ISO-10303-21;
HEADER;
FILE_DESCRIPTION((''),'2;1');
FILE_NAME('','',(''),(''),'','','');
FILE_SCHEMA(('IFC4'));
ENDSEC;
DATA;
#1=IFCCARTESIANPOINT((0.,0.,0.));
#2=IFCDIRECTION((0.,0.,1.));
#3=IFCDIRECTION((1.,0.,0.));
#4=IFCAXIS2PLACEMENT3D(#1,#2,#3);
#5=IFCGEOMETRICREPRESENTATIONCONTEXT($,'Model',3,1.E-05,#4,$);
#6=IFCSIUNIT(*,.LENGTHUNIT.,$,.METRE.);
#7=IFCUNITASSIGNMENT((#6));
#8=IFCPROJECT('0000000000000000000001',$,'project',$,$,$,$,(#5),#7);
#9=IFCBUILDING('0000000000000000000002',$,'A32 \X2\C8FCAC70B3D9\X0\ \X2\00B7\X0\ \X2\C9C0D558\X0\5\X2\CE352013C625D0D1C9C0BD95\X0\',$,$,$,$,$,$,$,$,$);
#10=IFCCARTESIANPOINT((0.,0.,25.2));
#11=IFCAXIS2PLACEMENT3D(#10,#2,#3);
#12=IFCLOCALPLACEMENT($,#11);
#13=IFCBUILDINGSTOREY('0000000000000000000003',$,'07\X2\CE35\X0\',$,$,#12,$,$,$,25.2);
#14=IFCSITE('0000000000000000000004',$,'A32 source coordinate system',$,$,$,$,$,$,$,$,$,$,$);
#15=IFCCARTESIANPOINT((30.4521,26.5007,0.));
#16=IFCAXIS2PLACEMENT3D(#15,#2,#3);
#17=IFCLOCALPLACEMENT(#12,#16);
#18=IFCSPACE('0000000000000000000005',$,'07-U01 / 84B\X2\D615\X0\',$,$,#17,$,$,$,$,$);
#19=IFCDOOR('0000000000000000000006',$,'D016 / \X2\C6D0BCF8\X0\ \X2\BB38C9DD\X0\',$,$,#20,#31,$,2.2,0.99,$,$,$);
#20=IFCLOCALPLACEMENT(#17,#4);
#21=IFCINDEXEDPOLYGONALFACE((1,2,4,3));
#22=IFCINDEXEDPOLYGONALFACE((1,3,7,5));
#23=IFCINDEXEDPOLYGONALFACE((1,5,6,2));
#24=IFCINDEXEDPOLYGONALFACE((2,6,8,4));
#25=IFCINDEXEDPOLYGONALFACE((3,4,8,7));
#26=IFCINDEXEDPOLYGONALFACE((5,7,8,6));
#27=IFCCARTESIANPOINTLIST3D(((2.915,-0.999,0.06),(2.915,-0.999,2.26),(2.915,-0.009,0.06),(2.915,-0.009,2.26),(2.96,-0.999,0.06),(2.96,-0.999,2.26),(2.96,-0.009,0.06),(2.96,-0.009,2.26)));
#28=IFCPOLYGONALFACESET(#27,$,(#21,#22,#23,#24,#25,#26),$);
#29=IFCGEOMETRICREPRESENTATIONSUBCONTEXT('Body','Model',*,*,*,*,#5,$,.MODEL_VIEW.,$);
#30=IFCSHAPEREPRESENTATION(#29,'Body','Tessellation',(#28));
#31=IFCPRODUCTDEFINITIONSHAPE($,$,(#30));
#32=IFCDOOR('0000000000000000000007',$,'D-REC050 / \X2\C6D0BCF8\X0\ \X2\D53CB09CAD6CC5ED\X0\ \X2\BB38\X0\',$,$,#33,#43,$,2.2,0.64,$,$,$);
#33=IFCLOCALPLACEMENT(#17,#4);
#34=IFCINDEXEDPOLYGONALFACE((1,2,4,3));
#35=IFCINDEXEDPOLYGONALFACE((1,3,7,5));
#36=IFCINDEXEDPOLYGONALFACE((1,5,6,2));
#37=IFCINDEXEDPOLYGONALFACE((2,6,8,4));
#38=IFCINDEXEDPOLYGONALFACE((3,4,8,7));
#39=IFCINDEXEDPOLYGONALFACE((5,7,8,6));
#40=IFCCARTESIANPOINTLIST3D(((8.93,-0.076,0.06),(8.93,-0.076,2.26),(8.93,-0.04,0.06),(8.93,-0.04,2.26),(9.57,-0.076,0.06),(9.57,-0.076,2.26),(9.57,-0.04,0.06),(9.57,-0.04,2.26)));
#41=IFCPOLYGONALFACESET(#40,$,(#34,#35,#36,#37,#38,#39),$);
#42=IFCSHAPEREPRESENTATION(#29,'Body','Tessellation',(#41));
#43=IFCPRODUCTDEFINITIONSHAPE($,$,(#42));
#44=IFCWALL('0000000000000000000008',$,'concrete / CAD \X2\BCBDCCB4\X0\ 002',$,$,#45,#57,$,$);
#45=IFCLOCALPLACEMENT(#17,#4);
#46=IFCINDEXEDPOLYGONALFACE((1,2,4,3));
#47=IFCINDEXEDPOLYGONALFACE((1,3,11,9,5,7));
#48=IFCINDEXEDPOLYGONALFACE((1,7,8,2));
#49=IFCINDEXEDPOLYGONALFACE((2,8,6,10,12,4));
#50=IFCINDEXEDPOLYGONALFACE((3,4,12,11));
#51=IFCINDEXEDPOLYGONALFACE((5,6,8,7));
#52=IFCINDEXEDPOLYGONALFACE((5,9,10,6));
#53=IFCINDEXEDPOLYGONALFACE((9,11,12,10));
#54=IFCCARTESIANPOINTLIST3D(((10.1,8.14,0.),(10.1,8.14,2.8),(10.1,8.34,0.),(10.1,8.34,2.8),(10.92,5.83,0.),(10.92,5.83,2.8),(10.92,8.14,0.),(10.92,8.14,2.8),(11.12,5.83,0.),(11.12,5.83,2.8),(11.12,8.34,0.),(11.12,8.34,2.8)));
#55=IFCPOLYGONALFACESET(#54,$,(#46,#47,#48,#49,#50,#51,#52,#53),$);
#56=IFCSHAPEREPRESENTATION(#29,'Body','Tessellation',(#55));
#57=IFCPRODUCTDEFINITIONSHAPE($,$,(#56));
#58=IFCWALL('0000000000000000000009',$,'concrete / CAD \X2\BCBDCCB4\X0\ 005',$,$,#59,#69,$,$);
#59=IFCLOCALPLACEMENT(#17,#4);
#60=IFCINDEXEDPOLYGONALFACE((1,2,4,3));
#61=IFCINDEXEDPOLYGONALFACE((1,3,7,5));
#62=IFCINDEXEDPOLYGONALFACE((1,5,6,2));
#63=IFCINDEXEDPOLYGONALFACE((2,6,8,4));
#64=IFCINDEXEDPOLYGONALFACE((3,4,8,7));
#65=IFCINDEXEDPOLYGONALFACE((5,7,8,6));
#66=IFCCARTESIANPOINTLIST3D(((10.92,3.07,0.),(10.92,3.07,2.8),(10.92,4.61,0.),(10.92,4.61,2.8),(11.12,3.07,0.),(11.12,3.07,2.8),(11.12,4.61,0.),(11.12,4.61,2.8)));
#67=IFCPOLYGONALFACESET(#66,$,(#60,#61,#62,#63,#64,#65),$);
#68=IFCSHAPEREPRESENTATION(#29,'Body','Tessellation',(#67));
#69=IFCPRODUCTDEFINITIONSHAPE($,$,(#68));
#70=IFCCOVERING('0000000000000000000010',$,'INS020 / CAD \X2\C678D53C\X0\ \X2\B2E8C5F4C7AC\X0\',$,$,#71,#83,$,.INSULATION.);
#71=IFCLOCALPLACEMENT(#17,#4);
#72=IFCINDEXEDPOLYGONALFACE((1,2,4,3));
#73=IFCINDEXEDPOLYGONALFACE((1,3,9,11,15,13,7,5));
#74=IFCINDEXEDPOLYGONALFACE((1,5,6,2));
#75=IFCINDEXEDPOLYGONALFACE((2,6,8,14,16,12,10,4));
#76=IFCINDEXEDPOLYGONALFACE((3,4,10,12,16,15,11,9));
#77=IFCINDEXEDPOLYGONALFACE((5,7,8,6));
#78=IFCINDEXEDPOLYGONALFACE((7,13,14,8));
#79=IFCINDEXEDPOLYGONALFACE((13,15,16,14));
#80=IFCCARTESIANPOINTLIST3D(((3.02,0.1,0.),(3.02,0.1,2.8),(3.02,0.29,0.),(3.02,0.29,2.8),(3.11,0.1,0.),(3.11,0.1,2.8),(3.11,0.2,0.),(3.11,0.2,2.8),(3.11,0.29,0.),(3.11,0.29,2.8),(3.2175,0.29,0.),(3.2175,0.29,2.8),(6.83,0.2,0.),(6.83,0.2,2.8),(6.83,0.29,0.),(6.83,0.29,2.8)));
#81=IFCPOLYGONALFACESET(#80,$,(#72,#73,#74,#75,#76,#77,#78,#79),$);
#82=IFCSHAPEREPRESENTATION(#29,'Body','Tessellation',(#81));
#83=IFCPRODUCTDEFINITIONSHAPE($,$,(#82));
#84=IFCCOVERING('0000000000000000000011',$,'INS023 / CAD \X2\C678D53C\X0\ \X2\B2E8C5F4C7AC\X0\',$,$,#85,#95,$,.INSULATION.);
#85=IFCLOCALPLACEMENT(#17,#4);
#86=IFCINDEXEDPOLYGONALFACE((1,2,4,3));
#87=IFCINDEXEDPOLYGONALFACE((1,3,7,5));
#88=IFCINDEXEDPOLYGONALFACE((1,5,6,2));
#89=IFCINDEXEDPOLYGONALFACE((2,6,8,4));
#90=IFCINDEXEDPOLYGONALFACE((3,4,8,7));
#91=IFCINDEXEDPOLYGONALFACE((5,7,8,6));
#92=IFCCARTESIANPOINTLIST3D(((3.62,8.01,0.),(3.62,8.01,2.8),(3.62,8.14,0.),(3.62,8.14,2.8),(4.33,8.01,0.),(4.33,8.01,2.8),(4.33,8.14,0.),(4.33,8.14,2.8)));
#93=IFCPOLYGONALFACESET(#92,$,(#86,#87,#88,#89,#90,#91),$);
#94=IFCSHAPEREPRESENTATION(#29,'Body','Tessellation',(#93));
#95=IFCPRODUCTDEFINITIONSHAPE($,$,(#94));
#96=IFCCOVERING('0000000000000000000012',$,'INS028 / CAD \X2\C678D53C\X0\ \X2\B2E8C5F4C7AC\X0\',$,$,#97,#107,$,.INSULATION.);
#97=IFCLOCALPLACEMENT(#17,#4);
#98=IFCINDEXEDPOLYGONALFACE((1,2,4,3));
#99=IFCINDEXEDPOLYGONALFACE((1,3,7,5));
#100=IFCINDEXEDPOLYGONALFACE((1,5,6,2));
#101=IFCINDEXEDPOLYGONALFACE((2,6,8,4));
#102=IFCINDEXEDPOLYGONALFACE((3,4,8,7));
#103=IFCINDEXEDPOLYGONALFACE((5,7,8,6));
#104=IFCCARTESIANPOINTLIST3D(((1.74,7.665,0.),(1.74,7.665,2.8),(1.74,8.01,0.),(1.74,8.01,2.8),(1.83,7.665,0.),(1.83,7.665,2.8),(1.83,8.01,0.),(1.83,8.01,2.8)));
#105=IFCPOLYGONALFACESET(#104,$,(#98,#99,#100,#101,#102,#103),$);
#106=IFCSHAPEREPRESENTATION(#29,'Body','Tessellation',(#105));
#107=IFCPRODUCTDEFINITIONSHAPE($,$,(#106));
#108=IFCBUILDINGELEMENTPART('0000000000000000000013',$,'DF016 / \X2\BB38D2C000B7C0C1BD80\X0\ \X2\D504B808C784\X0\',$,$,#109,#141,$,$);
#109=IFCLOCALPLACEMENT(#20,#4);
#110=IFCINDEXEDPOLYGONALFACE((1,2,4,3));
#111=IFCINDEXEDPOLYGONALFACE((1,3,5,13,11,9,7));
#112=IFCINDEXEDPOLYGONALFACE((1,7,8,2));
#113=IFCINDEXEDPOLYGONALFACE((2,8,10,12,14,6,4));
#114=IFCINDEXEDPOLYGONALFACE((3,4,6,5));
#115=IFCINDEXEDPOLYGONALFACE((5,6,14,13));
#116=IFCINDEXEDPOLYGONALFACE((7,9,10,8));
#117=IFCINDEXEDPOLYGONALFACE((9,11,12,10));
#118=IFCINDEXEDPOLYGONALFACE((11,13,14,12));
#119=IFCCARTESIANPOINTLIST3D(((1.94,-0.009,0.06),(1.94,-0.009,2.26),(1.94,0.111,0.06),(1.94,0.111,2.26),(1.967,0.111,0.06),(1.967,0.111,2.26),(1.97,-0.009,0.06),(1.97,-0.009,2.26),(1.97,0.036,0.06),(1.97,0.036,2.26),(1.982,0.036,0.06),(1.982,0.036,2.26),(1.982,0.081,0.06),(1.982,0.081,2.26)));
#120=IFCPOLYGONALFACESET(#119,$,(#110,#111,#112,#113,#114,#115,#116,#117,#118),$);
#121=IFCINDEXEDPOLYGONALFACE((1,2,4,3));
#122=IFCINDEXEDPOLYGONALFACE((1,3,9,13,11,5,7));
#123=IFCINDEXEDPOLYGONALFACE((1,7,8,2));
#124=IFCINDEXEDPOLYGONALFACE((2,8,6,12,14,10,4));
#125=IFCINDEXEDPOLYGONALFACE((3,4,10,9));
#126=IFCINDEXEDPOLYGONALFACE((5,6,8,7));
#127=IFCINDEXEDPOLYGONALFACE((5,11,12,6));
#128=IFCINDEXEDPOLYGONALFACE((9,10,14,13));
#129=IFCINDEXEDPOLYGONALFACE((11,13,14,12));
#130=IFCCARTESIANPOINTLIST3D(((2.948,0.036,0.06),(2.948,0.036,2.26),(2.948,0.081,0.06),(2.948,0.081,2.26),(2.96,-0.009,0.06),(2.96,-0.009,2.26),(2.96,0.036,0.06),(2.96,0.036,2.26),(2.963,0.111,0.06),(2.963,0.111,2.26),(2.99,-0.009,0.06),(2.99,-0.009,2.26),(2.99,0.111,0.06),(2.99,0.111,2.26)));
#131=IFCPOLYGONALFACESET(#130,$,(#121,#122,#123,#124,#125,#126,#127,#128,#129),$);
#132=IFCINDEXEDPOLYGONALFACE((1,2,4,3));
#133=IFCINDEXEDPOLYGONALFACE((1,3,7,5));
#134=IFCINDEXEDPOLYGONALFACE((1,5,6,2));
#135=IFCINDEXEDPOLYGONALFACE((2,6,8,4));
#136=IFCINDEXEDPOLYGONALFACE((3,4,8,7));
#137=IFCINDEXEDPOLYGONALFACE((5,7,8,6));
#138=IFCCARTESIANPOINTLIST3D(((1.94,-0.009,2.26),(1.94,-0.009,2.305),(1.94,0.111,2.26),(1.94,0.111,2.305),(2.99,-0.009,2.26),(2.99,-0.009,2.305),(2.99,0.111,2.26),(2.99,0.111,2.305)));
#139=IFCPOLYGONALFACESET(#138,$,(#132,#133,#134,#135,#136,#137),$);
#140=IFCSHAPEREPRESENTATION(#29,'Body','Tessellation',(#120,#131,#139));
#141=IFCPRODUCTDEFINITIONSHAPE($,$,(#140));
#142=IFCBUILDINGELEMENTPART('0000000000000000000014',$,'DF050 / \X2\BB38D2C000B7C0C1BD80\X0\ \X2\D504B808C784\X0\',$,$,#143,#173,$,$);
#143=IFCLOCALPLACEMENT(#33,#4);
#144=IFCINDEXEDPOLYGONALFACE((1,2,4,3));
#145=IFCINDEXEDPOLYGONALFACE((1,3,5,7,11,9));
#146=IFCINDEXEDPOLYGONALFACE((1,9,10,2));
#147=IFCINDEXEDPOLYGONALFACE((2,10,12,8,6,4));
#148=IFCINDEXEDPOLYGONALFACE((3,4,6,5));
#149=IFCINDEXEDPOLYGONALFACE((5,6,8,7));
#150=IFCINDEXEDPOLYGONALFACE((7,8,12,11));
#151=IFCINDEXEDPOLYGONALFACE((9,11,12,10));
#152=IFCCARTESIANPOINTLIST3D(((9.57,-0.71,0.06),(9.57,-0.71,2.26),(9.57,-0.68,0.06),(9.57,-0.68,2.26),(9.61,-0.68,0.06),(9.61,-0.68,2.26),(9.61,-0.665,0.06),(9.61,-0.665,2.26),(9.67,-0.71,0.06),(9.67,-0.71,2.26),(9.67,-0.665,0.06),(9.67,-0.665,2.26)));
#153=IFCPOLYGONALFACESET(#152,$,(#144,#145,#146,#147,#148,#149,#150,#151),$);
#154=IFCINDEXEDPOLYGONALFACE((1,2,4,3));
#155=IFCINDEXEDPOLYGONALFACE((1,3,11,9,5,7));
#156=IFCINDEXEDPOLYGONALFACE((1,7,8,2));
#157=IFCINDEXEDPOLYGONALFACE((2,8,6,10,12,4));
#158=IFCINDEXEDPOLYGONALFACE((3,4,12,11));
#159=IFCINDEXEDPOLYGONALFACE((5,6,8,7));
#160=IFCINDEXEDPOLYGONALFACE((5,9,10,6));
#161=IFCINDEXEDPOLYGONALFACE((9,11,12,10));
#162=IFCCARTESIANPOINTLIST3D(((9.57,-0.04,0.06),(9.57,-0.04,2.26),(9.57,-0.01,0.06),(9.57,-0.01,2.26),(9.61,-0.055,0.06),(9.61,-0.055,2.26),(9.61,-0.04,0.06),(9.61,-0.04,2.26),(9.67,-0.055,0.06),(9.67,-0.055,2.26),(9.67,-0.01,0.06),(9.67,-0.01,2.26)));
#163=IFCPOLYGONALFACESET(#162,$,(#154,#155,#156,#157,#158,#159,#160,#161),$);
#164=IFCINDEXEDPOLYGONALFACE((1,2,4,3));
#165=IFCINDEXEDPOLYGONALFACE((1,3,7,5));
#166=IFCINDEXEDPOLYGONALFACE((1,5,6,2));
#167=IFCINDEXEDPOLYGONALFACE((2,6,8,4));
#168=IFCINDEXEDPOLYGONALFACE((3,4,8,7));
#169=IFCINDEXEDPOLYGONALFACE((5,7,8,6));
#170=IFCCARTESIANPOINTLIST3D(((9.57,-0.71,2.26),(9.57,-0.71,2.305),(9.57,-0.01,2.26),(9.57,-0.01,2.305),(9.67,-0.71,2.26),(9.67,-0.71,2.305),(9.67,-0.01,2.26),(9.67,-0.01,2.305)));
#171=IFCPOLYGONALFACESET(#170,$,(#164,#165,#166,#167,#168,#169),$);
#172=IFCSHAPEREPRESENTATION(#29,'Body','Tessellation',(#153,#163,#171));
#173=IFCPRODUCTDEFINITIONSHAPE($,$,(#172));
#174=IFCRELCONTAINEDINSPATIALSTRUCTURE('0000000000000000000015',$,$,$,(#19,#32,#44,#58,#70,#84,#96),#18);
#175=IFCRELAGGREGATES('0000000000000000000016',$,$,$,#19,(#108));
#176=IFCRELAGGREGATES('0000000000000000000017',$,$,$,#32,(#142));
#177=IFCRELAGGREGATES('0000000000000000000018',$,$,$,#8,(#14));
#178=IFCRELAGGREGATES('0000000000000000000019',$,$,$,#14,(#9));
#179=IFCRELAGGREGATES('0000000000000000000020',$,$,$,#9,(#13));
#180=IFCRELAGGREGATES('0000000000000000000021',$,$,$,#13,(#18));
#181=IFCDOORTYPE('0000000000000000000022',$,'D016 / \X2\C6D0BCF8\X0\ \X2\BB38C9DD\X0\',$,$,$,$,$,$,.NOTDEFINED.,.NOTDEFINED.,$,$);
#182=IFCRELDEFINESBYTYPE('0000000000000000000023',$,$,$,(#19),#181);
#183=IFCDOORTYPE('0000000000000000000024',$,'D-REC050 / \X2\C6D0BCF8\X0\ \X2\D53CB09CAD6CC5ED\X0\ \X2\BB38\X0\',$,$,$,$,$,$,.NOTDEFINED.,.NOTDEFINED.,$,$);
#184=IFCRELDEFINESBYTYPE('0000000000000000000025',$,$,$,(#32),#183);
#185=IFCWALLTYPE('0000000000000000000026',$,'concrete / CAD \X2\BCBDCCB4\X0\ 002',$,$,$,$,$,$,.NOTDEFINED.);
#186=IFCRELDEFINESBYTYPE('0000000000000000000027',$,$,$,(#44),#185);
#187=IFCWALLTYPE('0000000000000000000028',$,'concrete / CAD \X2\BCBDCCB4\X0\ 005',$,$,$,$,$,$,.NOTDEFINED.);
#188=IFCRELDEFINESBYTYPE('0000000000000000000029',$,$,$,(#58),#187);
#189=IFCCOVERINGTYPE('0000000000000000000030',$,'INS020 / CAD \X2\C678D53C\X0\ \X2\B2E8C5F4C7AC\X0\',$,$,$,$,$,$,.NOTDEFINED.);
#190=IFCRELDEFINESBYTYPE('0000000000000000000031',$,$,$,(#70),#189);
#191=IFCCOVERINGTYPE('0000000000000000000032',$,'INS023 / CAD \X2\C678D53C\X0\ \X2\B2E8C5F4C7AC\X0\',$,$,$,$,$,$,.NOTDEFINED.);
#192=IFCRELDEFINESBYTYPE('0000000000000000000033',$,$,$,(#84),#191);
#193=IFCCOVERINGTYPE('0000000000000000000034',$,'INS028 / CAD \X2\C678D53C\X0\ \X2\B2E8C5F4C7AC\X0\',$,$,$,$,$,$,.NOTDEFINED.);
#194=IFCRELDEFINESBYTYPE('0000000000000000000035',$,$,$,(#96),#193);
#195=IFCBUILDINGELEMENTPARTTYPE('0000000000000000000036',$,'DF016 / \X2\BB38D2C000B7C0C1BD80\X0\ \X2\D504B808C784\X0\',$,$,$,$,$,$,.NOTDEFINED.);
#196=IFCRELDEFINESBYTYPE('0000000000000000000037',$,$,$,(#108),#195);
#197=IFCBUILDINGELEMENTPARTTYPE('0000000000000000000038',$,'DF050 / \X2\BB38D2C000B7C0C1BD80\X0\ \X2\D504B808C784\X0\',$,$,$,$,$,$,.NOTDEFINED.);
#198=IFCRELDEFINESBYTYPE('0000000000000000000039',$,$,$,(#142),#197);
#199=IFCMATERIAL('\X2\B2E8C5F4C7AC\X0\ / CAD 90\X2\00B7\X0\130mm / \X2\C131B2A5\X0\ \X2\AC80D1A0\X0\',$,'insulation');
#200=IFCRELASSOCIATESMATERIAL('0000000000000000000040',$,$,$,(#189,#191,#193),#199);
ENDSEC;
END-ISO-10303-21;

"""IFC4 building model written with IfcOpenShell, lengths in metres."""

from ifc_helpers import new_model, si_unit, frame, origin, origin_with_axes, place, context, subcontext, project, spatial, polyline, outline, extrude, source, transform, mapped, material, type_object, type_shapes, element, aggregate, save


model = new_model("IFC4")

# Units and contexts
model_context = context("Model", 3, precision=1e-05, world=origin_with_axes())
body_context = subcontext(model_context, "Body", "Model", "MODEL_VIEW")
ifc_project = project(units=[si_unit("LENGTHUNIT", "METRE")], contexts=[model_context])

# Site, building, storey, space
storey_placement = place(None, frame((0.0, 0.0, 25.2), z_axis=(0.0, 0.0, 1.0), x_axis=(1.0, 0.0, 0.0)))
space_placement = place(storey_placement, frame((30.4521, 26.5007, 0.0), z_axis=(0.0, 0.0, 1.0), x_axis=(1.0, 0.0, 0.0)))
site = spatial("IfcSite", under=ifc_project, Name="A32 source coordinate system")
building = spatial("IfcBuilding", under=site, Name="A32 주거동 · 지하5층–옥탑지붕")
storey = spatial("IfcBuildingStorey", under=building, at=storey_placement, Name="07층", Elevation=25.2)
space = spatial("IfcSpace", under=storey, at=space_placement, Name="07-U01 / 84B형")

# Doors
door_type_1 = type_object("IfcDoorType", Name="D016 / 원본 문짝", OperationType="NOTDEFINED", PredefinedType="NOTDEFINED")
shared_shape_1 = source(origin(), body_context, "Body", "SweptSolid", [
    extrude(outline(polyline([(2.96, -0.009), (2.96, -0.999), (2.915, -0.999), (2.915, -0.009), (2.96, -0.009)])), frame((0.0, 0.0, 0.06)), (0.0, 0.0, 1.0), 2.2),
])
type_shapes(door_type_1, [shared_shape_1])
door_1_placement = place(space_placement, origin_with_axes())
door_1 = element("IfcDoor", 1, at=door_1_placement, inside=space, type_object=door_type_1, Name="D016 / 원본 문짝", OverallHeight=2.2, OverallWidth=0.99, context=body_context, shape_type="MappedRepresentation", body=[
    mapped(shared_shape_1, transform((0.0, 0.0, 0.0), scale=1.0)),
])
door_type_2 = type_object("IfcDoorType", Name="D-REC050 / 원본 피난구역 문", OperationType="NOTDEFINED", PredefinedType="NOTDEFINED")
shared_shape_2 = source(origin(), body_context, "Body", "SweptSolid", [
    extrude(outline(polyline([(9.57, -0.04), (9.57, -0.076), (8.93, -0.076), (8.93, -0.04), (9.57, -0.04)])), frame((0.0, 0.0, 0.06)), (0.0, 0.0, 1.0), 2.2),
])
type_shapes(door_type_2, [shared_shape_2])
door_2_placement = place(space_placement, origin_with_axes())
door_2 = element("IfcDoor", 2, at=door_2_placement, inside=space, type_object=door_type_2, Name="D-REC050 / 원본 피난구역 문", OverallHeight=2.2, OverallWidth=0.64, context=body_context, shape_type="MappedRepresentation", body=[
    mapped(shared_shape_2, transform((0.0, 0.0, 0.0), scale=1.0)),
])

# Walls
wall_type_1 = type_object("IfcWallType", Name="concrete / CAD 벽체 002", PredefinedType="NOTDEFINED")
shared_shape_3 = source(origin(), body_context, "Body", "SweptSolid", [
    extrude(outline(polyline([(11.12, 5.83), (10.92, 5.83), (10.92, 8.14), (10.1, 8.14), (10.1, 8.34), (11.12, 8.34), (11.12, 5.83)])), origin(), (0.0, 0.0, 1.0), 2.8),
])
type_shapes(wall_type_1, [shared_shape_3])
wall_1_placement = place(space_placement, origin_with_axes())
element("IfcWall", 3, at=wall_1_placement, inside=space, type_object=wall_type_1, Name="concrete / CAD 벽체 002", context=body_context, shape_type="MappedRepresentation", body=[
    mapped(shared_shape_3, transform((0.0, 0.0, 0.0), scale=1.0)),
])
wall_type_2 = type_object("IfcWallType", Name="concrete / CAD 벽체 005", PredefinedType="NOTDEFINED")
shared_shape_4 = source(origin(), body_context, "Body", "SweptSolid", [
    extrude(outline(polyline([(11.12, 3.07), (10.92, 3.07), (10.92, 4.61), (11.12, 4.61), (11.12, 3.07)])), origin(), (0.0, 0.0, 1.0), 2.8),
])
type_shapes(wall_type_2, [shared_shape_4])
wall_2_placement = place(space_placement, origin_with_axes())
element("IfcWall", 4, at=wall_2_placement, inside=space, type_object=wall_type_2, Name="concrete / CAD 벽체 005", context=body_context, shape_type="MappedRepresentation", body=[
    mapped(shared_shape_4, transform((0.0, 0.0, 0.0), scale=1.0)),
])

# Coverings
ifc_material = material(Name="단열재 / CAD 90·130mm / 성능 검토", Category="insulation")
covering_type_1 = type_object("IfcCoveringType", Name="INS020 / CAD 외피 단열재", PredefinedType="NOTDEFINED", material=ifc_material)
shared_shape_5 = source(origin(), body_context, "Body", "SweptSolid", [
    extrude(outline(polyline([(3.11, 0.2), (3.11, 0.1), (3.02, 0.1), (3.02, 0.29), (3.11, 0.29), (3.2175, 0.29), (6.83, 0.29), (6.83, 0.2), (3.11, 0.2)])), origin(), (0.0, 0.0, 1.0), 2.8),
])
type_shapes(covering_type_1, [shared_shape_5])
covering_1_placement = place(space_placement, origin_with_axes())
element("IfcCovering", 5, at=covering_1_placement, inside=space, type_object=covering_type_1, Name="INS020 / CAD 외피 단열재", PredefinedType="INSULATION", context=body_context, shape_type="MappedRepresentation", body=[
    mapped(shared_shape_5, transform((0.0, 0.0, 0.0), scale=1.0)),
])
covering_type_2 = type_object("IfcCoveringType", Name="INS023 / CAD 외피 단열재", PredefinedType="NOTDEFINED", material=ifc_material)
shared_shape_6 = source(origin(), body_context, "Body", "SweptSolid", [
    extrude(outline(polyline([(4.33, 8.01), (3.62, 8.01), (3.62, 8.14), (4.33, 8.14), (4.33, 8.01)])), origin(), (0.0, 0.0, 1.0), 2.8),
])
type_shapes(covering_type_2, [shared_shape_6])
covering_2_placement = place(space_placement, origin_with_axes())
element("IfcCovering", 6, at=covering_2_placement, inside=space, type_object=covering_type_2, Name="INS023 / CAD 외피 단열재", PredefinedType="INSULATION", context=body_context, shape_type="MappedRepresentation", body=[
    mapped(shared_shape_6, transform((0.0, 0.0, 0.0), scale=1.0)),
])
covering_type_3 = type_object("IfcCoveringType", Name="INS028 / CAD 외피 단열재", PredefinedType="NOTDEFINED", material=ifc_material)
shared_shape_7 = source(origin(), body_context, "Body", "SweptSolid", [
    extrude(outline(polyline([(1.74, 8.01), (1.83, 8.01), (1.83, 7.665), (1.74, 7.665), (1.74, 8.01)])), origin(), (0.0, 0.0, 1.0), 2.8),
])
type_shapes(covering_type_3, [shared_shape_7])
covering_3_placement = place(space_placement, origin_with_axes())
element("IfcCovering", 7, at=covering_3_placement, inside=space, type_object=covering_type_3, Name="INS028 / CAD 외피 단열재", PredefinedType="INSULATION", context=body_context, shape_type="MappedRepresentation", body=[
    mapped(shared_shape_7, transform((0.0, 0.0, 0.0), scale=1.0)),
])

# Building element parts
building_element_part_type_1 = type_object("IfcBuildingElementPartType", Name="DF016 / 문틀·상부 프레임", PredefinedType="NOTDEFINED")
shared_shape_8 = source(origin(), body_context, "Body", "SweptSolid", [
    extrude(outline(polyline([(1.94, 0.111), (1.967, 0.111), (1.982, 0.081), (1.982, 0.036), (1.97, 0.036), (1.97, -0.009), (1.94, -0.009), (1.94, 0.111)])), frame((0.0, 0.0, 0.06)), (0.0, 0.0, 1.0), 2.2),
    extrude(outline(polyline([(2.96, -0.009), (2.96, 0.036), (2.948, 0.036), (2.948, 0.081), (2.963, 0.111), (2.99, 0.111), (2.99, -0.009), (2.96, -0.009)])), frame((0.0, 0.0, 0.06)), (0.0, 0.0, 1.0), 2.2),
    extrude(outline(polyline([(1.94, -0.009), (1.94, 0.111), (2.99, 0.111), (2.99, -0.009), (1.94, -0.009)])), frame((0.0, 0.0, 2.26)), (0.0, 0.0, 1.0), 0.045),
])
type_shapes(building_element_part_type_1, [shared_shape_8])
building_element_part_1_placement = place(door_1_placement, origin_with_axes())
building_element_part_1 = element("IfcBuildingElementPart", 8, at=building_element_part_1_placement, type_object=building_element_part_type_1, Name="DF016 / 문틀·상부 프레임", context=body_context, shape_type="MappedRepresentation", body=[
    mapped(shared_shape_8, transform((0.0, 0.0, 0.0), scale=1.0)),
])
aggregate(door_1, [building_element_part_1])
building_element_part_type_2 = type_object("IfcBuildingElementPartType", Name="DF050 / 문틀·상부 프레임", PredefinedType="NOTDEFINED")
shared_shape_9 = source(origin(), body_context, "Body", "SweptSolid", [
    extrude(outline(polyline([(9.57, -0.68), (9.61, -0.68), (9.61, -0.665), (9.67, -0.665), (9.67, -0.71), (9.57, -0.71), (9.57, -0.68)])), frame((0.0, 0.0, 0.06)), (0.0, 0.0, 1.0), 2.2),
    extrude(outline(polyline([(9.67, -0.01), (9.67, -0.055), (9.61, -0.055), (9.61, -0.04), (9.57, -0.04), (9.57, -0.01), (9.67, -0.01)])), frame((0.0, 0.0, 0.06)), (0.0, 0.0, 1.0), 2.2),
    extrude(outline(polyline([(9.57, -0.71), (9.57, -0.01), (9.67, -0.01), (9.67, -0.71), (9.57, -0.71)])), frame((0.0, 0.0, 2.26)), (0.0, 0.0, 1.0), 0.045),
])
type_shapes(building_element_part_type_2, [shared_shape_9])
building_element_part_2_placement = place(door_2_placement, origin_with_axes())
building_element_part_2 = element("IfcBuildingElementPart", 9, at=building_element_part_2_placement, type_object=building_element_part_type_2, Name="DF050 / 문틀·상부 프레임", context=body_context, shape_type="MappedRepresentation", body=[
    mapped(shared_shape_9, transform((0.0, 0.0, 0.0), scale=1.0)),
])
aggregate(door_2, [building_element_part_2])

save(model, "model.ifc")
